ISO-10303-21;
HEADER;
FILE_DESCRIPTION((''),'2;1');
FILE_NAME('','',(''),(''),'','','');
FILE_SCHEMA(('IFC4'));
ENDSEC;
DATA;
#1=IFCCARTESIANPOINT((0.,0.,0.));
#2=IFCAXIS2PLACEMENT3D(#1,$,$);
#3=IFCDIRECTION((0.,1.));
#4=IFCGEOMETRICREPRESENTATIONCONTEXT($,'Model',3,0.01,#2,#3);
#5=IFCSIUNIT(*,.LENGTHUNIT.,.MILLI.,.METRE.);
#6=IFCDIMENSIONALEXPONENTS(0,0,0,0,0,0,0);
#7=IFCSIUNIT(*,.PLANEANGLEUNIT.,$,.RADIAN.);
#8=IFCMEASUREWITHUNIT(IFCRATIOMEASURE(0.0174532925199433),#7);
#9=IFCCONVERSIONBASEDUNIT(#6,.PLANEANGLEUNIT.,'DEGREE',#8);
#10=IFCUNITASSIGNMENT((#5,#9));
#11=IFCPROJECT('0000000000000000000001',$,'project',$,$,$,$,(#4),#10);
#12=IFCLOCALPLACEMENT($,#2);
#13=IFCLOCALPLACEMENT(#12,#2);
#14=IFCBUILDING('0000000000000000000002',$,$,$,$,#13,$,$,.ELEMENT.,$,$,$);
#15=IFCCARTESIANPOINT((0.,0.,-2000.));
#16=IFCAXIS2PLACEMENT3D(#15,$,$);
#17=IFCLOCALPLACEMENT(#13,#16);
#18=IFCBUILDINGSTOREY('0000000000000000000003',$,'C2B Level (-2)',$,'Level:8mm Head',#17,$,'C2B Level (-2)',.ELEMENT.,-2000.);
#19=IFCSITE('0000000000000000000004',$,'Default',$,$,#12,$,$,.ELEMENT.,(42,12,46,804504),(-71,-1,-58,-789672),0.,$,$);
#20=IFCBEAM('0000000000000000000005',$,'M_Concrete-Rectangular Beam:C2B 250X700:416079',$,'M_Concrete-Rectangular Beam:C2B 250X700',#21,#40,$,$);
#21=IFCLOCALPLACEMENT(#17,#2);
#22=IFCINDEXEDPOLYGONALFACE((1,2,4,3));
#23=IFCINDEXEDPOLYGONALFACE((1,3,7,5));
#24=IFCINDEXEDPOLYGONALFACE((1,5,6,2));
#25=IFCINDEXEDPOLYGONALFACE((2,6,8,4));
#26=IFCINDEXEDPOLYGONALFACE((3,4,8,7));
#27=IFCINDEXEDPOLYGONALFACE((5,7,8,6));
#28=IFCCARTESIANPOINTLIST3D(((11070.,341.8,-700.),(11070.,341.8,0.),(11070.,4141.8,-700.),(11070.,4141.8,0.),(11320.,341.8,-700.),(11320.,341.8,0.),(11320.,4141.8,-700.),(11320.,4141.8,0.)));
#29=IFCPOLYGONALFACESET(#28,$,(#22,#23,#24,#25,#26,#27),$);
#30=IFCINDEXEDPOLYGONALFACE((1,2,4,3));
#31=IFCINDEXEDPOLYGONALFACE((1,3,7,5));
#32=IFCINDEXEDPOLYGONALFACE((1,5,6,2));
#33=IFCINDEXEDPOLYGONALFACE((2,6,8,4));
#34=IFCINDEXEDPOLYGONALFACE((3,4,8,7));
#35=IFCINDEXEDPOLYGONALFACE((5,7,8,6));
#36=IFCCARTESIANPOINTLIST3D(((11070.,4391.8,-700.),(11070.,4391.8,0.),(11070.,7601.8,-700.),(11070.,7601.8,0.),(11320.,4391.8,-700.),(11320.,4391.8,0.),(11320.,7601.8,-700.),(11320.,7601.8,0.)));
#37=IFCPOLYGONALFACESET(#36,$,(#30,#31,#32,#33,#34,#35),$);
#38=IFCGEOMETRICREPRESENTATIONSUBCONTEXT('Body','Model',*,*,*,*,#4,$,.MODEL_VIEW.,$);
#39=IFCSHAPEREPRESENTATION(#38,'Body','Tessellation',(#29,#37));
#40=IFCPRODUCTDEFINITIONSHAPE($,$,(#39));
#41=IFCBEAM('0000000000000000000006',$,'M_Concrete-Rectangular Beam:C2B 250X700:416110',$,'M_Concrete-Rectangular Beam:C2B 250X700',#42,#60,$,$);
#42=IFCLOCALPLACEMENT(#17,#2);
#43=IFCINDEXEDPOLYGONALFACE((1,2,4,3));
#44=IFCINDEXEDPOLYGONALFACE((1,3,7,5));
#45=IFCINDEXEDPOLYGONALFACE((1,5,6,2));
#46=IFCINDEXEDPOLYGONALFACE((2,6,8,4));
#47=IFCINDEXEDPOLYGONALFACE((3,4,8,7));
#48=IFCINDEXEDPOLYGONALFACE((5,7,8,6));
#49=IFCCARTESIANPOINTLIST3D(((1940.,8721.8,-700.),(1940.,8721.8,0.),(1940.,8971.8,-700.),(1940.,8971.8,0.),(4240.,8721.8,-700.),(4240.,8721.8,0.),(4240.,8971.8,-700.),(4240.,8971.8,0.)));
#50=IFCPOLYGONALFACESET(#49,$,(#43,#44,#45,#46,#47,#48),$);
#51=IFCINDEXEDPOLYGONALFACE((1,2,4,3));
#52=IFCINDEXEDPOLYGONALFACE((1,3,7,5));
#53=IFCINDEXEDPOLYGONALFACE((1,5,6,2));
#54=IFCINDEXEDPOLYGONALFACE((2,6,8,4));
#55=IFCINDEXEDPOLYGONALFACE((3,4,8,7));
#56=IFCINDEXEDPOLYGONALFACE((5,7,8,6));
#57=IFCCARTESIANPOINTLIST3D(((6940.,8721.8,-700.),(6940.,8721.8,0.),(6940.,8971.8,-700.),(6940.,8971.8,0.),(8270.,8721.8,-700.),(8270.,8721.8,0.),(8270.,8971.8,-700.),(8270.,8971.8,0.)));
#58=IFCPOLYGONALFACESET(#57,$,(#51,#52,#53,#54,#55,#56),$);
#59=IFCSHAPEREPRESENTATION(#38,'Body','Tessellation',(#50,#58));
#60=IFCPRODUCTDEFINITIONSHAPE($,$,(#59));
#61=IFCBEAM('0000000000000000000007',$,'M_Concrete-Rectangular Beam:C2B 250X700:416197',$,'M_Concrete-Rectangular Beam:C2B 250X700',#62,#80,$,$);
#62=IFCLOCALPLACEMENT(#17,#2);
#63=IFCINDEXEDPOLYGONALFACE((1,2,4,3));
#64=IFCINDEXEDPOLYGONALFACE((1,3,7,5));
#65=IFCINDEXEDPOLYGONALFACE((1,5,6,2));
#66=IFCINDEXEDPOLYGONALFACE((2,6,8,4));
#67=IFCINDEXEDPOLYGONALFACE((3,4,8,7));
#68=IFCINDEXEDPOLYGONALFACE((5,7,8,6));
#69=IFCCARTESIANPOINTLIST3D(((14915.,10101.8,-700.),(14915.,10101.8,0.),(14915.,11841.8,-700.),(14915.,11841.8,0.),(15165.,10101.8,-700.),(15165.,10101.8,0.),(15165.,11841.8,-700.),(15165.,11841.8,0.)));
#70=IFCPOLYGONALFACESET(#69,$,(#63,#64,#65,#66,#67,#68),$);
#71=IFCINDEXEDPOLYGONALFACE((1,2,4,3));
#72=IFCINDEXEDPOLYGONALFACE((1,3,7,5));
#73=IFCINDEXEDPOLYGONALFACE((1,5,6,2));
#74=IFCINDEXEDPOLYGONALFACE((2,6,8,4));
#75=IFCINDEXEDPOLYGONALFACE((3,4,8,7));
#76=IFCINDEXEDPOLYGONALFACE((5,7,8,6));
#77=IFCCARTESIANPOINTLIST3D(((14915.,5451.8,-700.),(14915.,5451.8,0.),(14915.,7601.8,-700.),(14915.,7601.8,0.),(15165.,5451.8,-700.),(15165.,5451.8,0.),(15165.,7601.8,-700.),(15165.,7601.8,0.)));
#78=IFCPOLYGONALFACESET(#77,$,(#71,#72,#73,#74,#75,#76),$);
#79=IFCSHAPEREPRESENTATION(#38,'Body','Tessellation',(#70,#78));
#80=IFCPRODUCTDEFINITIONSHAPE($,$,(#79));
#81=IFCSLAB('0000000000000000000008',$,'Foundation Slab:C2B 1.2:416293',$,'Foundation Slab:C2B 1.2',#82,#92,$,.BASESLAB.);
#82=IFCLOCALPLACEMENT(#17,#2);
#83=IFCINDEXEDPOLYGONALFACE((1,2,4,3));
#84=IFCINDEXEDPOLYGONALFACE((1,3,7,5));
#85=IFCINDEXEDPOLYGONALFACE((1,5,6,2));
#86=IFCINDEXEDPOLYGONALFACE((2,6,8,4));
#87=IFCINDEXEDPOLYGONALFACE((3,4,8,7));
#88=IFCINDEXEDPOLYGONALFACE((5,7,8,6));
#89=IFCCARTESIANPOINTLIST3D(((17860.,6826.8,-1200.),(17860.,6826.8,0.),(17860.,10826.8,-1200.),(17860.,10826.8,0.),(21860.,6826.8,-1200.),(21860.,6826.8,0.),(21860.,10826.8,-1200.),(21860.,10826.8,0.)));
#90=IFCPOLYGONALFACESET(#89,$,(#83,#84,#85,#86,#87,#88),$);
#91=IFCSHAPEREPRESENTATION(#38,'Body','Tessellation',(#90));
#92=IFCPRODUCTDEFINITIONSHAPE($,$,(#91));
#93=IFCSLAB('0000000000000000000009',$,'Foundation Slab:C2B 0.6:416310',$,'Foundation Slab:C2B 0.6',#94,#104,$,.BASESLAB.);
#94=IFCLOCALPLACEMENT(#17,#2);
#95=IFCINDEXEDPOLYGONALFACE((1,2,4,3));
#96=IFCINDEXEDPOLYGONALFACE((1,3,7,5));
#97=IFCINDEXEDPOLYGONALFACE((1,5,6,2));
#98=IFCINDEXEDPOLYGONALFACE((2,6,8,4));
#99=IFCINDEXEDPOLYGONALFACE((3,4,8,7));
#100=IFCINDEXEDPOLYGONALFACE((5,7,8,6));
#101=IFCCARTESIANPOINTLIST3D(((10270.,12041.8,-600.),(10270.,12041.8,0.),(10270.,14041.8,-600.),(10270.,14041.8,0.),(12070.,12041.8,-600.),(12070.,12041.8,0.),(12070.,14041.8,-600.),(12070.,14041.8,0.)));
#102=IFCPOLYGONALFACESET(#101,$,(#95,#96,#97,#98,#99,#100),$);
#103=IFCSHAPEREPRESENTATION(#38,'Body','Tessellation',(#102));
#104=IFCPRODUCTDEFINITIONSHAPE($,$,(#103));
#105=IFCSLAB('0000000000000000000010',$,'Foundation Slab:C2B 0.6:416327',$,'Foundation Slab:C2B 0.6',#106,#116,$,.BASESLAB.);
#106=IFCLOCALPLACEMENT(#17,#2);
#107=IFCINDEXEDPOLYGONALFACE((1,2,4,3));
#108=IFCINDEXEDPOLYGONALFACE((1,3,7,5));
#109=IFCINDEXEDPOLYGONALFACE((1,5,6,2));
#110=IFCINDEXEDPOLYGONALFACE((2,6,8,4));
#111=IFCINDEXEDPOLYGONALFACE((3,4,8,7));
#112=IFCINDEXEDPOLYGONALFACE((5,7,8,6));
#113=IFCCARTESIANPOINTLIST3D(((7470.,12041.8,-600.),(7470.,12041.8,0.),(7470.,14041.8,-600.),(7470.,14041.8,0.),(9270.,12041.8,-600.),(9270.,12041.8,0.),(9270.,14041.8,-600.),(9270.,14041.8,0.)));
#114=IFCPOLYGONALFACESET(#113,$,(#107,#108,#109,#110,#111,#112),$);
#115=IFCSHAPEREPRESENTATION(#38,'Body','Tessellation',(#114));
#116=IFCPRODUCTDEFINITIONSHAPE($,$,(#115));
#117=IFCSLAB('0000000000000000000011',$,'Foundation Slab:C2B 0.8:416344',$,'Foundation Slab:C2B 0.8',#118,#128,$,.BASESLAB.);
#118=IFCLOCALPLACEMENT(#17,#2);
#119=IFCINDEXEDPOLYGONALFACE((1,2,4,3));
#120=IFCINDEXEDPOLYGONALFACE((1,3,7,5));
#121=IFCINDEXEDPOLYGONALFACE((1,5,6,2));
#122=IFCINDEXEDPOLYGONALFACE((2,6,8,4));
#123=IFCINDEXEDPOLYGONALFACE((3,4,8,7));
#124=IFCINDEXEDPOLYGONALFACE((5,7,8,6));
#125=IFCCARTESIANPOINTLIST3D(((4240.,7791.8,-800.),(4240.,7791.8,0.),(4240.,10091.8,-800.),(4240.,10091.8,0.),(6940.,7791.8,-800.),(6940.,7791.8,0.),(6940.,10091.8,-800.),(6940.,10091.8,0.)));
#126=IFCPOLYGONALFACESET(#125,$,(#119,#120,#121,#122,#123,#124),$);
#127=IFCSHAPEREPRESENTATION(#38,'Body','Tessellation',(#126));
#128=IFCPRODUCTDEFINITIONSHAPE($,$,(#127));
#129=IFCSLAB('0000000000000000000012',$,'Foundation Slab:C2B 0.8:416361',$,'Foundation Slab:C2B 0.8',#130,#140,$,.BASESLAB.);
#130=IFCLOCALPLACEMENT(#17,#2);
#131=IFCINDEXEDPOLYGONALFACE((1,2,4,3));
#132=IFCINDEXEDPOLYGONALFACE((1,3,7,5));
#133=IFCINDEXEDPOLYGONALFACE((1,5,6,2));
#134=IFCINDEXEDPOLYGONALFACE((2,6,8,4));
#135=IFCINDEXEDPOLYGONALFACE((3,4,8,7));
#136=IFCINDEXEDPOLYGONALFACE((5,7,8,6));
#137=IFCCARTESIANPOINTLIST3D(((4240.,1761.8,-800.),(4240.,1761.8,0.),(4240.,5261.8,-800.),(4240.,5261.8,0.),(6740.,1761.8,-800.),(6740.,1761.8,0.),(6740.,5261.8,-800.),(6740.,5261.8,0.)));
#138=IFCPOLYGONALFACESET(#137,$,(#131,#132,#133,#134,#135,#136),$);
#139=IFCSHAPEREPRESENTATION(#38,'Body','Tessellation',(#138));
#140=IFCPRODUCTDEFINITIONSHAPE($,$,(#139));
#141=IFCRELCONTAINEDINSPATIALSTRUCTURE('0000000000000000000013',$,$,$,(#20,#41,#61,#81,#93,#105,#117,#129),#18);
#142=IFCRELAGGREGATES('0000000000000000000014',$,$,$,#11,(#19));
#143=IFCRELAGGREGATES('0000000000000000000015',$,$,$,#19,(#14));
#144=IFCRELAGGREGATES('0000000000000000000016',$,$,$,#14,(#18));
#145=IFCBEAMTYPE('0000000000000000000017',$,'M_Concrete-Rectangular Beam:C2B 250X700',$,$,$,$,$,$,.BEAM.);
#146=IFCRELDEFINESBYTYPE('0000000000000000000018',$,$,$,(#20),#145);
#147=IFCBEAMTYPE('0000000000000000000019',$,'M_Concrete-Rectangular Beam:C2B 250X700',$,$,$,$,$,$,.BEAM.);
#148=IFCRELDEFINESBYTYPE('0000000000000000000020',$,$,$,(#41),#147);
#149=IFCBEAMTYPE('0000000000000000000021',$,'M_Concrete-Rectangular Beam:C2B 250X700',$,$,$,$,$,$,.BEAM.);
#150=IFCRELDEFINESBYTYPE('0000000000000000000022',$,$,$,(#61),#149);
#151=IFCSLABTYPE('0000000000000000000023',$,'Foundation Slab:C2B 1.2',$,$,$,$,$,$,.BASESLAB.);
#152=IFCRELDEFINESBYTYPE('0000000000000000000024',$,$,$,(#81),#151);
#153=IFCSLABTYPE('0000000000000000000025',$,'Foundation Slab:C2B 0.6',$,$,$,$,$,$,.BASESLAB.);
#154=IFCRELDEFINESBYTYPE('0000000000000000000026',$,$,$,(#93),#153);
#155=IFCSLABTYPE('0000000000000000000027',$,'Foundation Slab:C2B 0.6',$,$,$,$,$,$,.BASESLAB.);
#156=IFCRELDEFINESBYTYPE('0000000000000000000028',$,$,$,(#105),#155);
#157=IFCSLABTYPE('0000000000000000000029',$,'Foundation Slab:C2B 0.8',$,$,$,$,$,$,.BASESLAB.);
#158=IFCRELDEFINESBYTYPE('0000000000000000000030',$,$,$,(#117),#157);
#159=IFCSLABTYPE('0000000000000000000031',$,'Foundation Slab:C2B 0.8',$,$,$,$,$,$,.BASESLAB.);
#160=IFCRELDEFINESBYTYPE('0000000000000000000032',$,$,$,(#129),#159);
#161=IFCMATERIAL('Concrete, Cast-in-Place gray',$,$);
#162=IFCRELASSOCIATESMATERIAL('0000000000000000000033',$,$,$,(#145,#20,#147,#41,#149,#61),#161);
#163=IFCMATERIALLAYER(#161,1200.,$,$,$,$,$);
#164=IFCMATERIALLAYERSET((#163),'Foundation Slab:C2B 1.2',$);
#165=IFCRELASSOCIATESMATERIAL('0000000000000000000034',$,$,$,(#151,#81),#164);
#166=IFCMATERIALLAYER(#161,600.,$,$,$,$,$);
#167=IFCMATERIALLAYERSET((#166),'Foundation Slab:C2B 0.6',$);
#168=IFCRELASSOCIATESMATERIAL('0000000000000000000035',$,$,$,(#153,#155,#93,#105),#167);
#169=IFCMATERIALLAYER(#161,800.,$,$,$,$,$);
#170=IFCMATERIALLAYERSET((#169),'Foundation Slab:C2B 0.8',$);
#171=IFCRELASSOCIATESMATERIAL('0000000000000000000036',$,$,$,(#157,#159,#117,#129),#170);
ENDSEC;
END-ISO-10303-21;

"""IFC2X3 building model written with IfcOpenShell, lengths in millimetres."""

from ifc_helpers import new_model, entity, si_unit, converted_unit, direction, frame, frame_2d, origin, place, context, subcontext, project, spatial, rectangle, extrude, source, transform, mapped, material, layer, layer_set, layer_usage, type_object, type_shapes, element, save


model = new_model("IFC2X3")

# Units and contexts
model_context = context("Model", 3, precision=0.01, world=origin(), true_north=direction((0.0, 1.0)))
body_context = subcontext(model_context, "Body", "Model", "MODEL_VIEW")
ifc_project = project(units=[si_unit("LENGTHUNIT", "METRE", prefix="MILLI"), converted_unit("PLANEANGLEUNIT", "DEGREE", entity("IfcRatioMeasure", 0.0174532925199433), si_unit("PLANEANGLEUNIT", "RADIAN"), dimensions=[0, 0, 0, 0, 0, 0, 0])], contexts=[model_context])

# Site, building, storey
site_placement = place(None, origin())
site = spatial("IfcSite", under=ifc_project, at=site_placement, Name="Default", CompositionType="ELEMENT", RefLatitude=(42, 12, 46, 804504), RefLongitude=(-71, -1, -58, -789672), RefElevation=0.0)
building_placement = place(site_placement, origin())
building = spatial("IfcBuilding", under=site, at=building_placement, CompositionType="ELEMENT")
storey_placement = place(building_placement, frame((0.0, 0.0, -2000.0)))
storey = spatial("IfcBuildingStorey", under=building, at=storey_placement, Name="C2B Level (-2)", ObjectType="Level:8mm Head", LongName="C2B Level (-2)", CompositionType="ELEMENT", Elevation=-2000.0)

# Shared definitions
ifc_material = material(Name="Concrete, Cast-in-Place gray")

# Beams
beam_type_1 = type_object("IfcBeamType", Name="M_Concrete-Rectangular Beam:C2B 250X700", PredefinedType="BEAM", material=ifc_material)
shared_shape_1 = source(origin(), body_context, "Body", "SweptSolid", [
    extrude(rectangle(XDim=700.0, YDim=250.0, at=frame_2d((0.0, 0.0), x_axis=(0.0, 1.0))), frame((11195.0, 4141.8, -2350.0), z_axis=(0.0, -1.0, 0.0), x_axis=(-1.0, 0.0, 0.0)), (0.0, 0.0, 1.0), 3800.0),
    extrude(rectangle(XDim=700.0, YDim=250.0, at=frame_2d((0.0, 0.0), x_axis=(0.0, 1.0))), frame((11195.0, 7601.8, -2350.0), z_axis=(0.0, -1.0, 0.0), x_axis=(-1.0, 0.0, 0.0)), (0.0, 0.0, 1.0), 3210.0),
])
type_shapes(beam_type_1, [shared_shape_1])
beam_1_placement = place(storey_placement, frame((0.0, 0.0, 2000.0)))
element("IfcBeam", 1, at=beam_1_placement, inside=storey, type_object=beam_type_1, material=ifc_material, Name="M_Concrete-Rectangular Beam:C2B 250X700:416079", ObjectType="M_Concrete-Rectangular Beam:C2B 250X700", context=body_context, shape_type="MappedRepresentation", body=[
    mapped(shared_shape_1, transform((0.0, 0.0, 0.0), scale=1.0)),
])
beam_type_2 = type_object("IfcBeamType", Name="M_Concrete-Rectangular Beam:C2B 250X700", PredefinedType="BEAM", material=ifc_material)
shared_shape_2 = source(origin(), body_context, "Body", "SweptSolid", [
    extrude(rectangle(XDim=700.0, YDim=250.0, at=frame_2d((0.0, 0.0), x_axis=(1.0, 0.0))), frame((1940.0, 8846.8, -2350.0), z_axis=(1.0, 0.0, 0.0), x_axis=(0.0, 0.0, -1.0)), (0.0, 0.0, 1.0), 2300.0),
    extrude(rectangle(XDim=700.0, YDim=250.0, at=frame_2d((0.0, 0.0), x_axis=(1.0, 0.0))), frame((6940.0, 8846.8, -2350.0), z_axis=(1.0, 0.0, 0.0), x_axis=(0.0, 0.0, -1.0)), (0.0, 0.0, 1.0), 1330.0),
])
type_shapes(beam_type_2, [shared_shape_2])
beam_2_placement = place(storey_placement, frame((0.0, 0.0, 2000.0)))
element("IfcBeam", 2, at=beam_2_placement, inside=storey, type_object=beam_type_2, material=ifc_material, Name="M_Concrete-Rectangular Beam:C2B 250X700:416110", ObjectType="M_Concrete-Rectangular Beam:C2B 250X700", context=body_context, shape_type="MappedRepresentation", body=[
    mapped(shared_shape_2, transform((0.0, 0.0, 0.0), scale=1.0)),
])
beam_type_3 = type_object("IfcBeamType", Name="M_Concrete-Rectangular Beam:C2B 250X700", PredefinedType="BEAM", material=ifc_material)
shared_shape_3 = source(origin(), body_context, "Body", "SweptSolid", [
    extrude(rectangle(XDim=700.0, YDim=250.0, at=frame_2d((0.0, 0.0), x_axis=(0.0, 1.0))), frame((15040.0, 11841.8, -2350.0), z_axis=(0.0, -1.0, 0.0), x_axis=(-1.0, 0.0, 0.0)), (0.0, 0.0, 1.0), 1740.0),
    extrude(rectangle(XDim=700.0, YDim=250.0, at=frame_2d((0.0, 0.0), x_axis=(0.0, 1.0))), frame((15040.0, 7601.8, -2350.0), z_axis=(0.0, -1.0, 0.0), x_axis=(-1.0, 0.0, 0.0)), (0.0, 0.0, 1.0), 2150.0),
])
type_shapes(beam_type_3, [shared_shape_3])
beam_3_placement = place(storey_placement, frame((0.0, 0.0, 2000.0)))
element("IfcBeam", 3, at=beam_3_placement, inside=storey, type_object=beam_type_3, material=ifc_material, Name="M_Concrete-Rectangular Beam:C2B 250X700:416197", ObjectType="M_Concrete-Rectangular Beam:C2B 250X700", context=body_context, shape_type="MappedRepresentation", body=[
    mapped(shared_shape_3, transform((0.0, 0.0, 0.0), scale=1.0)),
])

# Slabs
ifc_layer_1 = layer(ifc_material, 1200.0)
ifc_layer_set_1 = layer_set([ifc_layer_1], Name="Foundation Slab:C2B 1.2")
ifc_layer_usage_1 = layer_usage(ifc_layer_set_1, "AXIS3", "POSITIVE", 0.0)
slab_type_1 = type_object("IfcSlabType", Name="Foundation Slab:C2B 1.2", PredefinedType="BASESLAB", material=ifc_layer_set_1)
slab_1_placement = place(storey_placement, origin())
element("IfcSlab", 4, at=slab_1_placement, inside=storey, type_object=slab_type_1, material=ifc_layer_usage_1, Name="Foundation Slab:C2B 1.2:416293", ObjectType="Foundation Slab:C2B 1.2", PredefinedType="BASESLAB", context=body_context, shape_type="SweptSolid", body=[
    extrude(rectangle(XDim=4000.0, YDim=4000.0, at=frame_2d((0.0, 0.0), x_axis=(1.0, 0.0))), frame((19860.0, 8826.8, 0.0), z_axis=(0.0, 0.0, -1.0), x_axis=(0.0, 1.0, 0.0)), (0.0, 0.0, 1.0), 1200.0),
])
ifc_layer_2 = layer(ifc_material, 600.0)
ifc_layer_set_2 = layer_set([ifc_layer_2], Name="Foundation Slab:C2B 0.6")
ifc_layer_usage_2 = layer_usage(ifc_layer_set_2, "AXIS3", "POSITIVE", 0.0)
slab_type_2 = type_object("IfcSlabType", Name="Foundation Slab:C2B 0.6", PredefinedType="BASESLAB", material=ifc_layer_set_2)
slab_2_placement = place(storey_placement, origin())
element("IfcSlab", 5, at=slab_2_placement, inside=storey, type_object=slab_type_2, material=ifc_layer_usage_2, Name="Foundation Slab:C2B 0.6:416310", ObjectType="Foundation Slab:C2B 0.6", PredefinedType="BASESLAB", context=body_context, shape_type="SweptSolid", body=[
    extrude(rectangle(XDim=2000.0, YDim=1800.0, at=frame_2d((0.0, 0.0), x_axis=(1.0, 0.0))), frame((11170.0, 13041.8, 0.0), z_axis=(0.0, 0.0, -1.0), x_axis=(0.0, 1.0, 0.0)), (0.0, 0.0, 1.0), 600.0),
])
ifc_layer_usage_3 = layer_usage(ifc_layer_set_2, "AXIS3", "POSITIVE", 0.0)
slab_type_3 = type_object("IfcSlabType", Name="Foundation Slab:C2B 0.6", PredefinedType="BASESLAB", material=ifc_layer_set_2)
slab_3_placement = place(storey_placement, origin())
element("IfcSlab", 6, at=slab_3_placement, inside=storey, type_object=slab_type_3, material=ifc_layer_usage_3, Name="Foundation Slab:C2B 0.6:416327", ObjectType="Foundation Slab:C2B 0.6", PredefinedType="BASESLAB", context=body_context, shape_type="SweptSolid", body=[
    extrude(rectangle(XDim=2000.0, YDim=1800.0, at=frame_2d((0.0, 0.0), x_axis=(1.0, 0.0))), frame((8370.0, 13041.8, 0.0), z_axis=(0.0, 0.0, -1.0), x_axis=(0.0, 1.0, 0.0)), (0.0, 0.0, 1.0), 600.0),
])
ifc_layer_3 = layer(ifc_material, 800.0)
ifc_layer_set_3 = layer_set([ifc_layer_3], Name="Foundation Slab:C2B 0.8")
ifc_layer_usage_4 = layer_usage(ifc_layer_set_3, "AXIS3", "POSITIVE", 0.0)
slab_type_4 = type_object("IfcSlabType", Name="Foundation Slab:C2B 0.8", PredefinedType="BASESLAB", material=ifc_layer_set_3)
slab_4_placement = place(storey_placement, origin())
element("IfcSlab", 7, at=slab_4_placement, inside=storey, type_object=slab_type_4, material=ifc_layer_usage_4, Name="Foundation Slab:C2B 0.8:416344", ObjectType="Foundation Slab:C2B 0.8", PredefinedType="BASESLAB", context=body_context, shape_type="SweptSolid", body=[
    extrude(rectangle(XDim=2300.0, YDim=2700.0, at=frame_2d((0.0, 0.0), x_axis=(1.0, 0.0))), frame((5590.0, 8941.8, 0.0), z_axis=(0.0, 0.0, -1.0), x_axis=(0.0, 1.0, 0.0)), (0.0, 0.0, 1.0), 800.0),
])
ifc_layer_usage_5 = layer_usage(ifc_layer_set_3, "AXIS3", "POSITIVE", 0.0)
slab_type_5 = type_object("IfcSlabType", Name="Foundation Slab:C2B 0.8", PredefinedType="BASESLAB", material=ifc_layer_set_3)
slab_5_placement = place(storey_placement, origin())
element("IfcSlab", 8, at=slab_5_placement, inside=storey, type_object=slab_type_5, material=ifc_layer_usage_5, Name="Foundation Slab:C2B 0.8:416361", ObjectType="Foundation Slab:C2B 0.8", PredefinedType="BASESLAB", context=body_context, shape_type="SweptSolid", body=[
    extrude(rectangle(XDim=3500.0, YDim=2500.0, at=frame_2d((0.0, 0.0), x_axis=(1.0, 0.0))), frame((5490.0, 3511.8, 0.0), z_axis=(0.0, 0.0, -1.0), x_axis=(0.0, 1.0, 0.0)), (0.0, 0.0, 1.0), 800.0),
])

save(model, "model.ifc")
